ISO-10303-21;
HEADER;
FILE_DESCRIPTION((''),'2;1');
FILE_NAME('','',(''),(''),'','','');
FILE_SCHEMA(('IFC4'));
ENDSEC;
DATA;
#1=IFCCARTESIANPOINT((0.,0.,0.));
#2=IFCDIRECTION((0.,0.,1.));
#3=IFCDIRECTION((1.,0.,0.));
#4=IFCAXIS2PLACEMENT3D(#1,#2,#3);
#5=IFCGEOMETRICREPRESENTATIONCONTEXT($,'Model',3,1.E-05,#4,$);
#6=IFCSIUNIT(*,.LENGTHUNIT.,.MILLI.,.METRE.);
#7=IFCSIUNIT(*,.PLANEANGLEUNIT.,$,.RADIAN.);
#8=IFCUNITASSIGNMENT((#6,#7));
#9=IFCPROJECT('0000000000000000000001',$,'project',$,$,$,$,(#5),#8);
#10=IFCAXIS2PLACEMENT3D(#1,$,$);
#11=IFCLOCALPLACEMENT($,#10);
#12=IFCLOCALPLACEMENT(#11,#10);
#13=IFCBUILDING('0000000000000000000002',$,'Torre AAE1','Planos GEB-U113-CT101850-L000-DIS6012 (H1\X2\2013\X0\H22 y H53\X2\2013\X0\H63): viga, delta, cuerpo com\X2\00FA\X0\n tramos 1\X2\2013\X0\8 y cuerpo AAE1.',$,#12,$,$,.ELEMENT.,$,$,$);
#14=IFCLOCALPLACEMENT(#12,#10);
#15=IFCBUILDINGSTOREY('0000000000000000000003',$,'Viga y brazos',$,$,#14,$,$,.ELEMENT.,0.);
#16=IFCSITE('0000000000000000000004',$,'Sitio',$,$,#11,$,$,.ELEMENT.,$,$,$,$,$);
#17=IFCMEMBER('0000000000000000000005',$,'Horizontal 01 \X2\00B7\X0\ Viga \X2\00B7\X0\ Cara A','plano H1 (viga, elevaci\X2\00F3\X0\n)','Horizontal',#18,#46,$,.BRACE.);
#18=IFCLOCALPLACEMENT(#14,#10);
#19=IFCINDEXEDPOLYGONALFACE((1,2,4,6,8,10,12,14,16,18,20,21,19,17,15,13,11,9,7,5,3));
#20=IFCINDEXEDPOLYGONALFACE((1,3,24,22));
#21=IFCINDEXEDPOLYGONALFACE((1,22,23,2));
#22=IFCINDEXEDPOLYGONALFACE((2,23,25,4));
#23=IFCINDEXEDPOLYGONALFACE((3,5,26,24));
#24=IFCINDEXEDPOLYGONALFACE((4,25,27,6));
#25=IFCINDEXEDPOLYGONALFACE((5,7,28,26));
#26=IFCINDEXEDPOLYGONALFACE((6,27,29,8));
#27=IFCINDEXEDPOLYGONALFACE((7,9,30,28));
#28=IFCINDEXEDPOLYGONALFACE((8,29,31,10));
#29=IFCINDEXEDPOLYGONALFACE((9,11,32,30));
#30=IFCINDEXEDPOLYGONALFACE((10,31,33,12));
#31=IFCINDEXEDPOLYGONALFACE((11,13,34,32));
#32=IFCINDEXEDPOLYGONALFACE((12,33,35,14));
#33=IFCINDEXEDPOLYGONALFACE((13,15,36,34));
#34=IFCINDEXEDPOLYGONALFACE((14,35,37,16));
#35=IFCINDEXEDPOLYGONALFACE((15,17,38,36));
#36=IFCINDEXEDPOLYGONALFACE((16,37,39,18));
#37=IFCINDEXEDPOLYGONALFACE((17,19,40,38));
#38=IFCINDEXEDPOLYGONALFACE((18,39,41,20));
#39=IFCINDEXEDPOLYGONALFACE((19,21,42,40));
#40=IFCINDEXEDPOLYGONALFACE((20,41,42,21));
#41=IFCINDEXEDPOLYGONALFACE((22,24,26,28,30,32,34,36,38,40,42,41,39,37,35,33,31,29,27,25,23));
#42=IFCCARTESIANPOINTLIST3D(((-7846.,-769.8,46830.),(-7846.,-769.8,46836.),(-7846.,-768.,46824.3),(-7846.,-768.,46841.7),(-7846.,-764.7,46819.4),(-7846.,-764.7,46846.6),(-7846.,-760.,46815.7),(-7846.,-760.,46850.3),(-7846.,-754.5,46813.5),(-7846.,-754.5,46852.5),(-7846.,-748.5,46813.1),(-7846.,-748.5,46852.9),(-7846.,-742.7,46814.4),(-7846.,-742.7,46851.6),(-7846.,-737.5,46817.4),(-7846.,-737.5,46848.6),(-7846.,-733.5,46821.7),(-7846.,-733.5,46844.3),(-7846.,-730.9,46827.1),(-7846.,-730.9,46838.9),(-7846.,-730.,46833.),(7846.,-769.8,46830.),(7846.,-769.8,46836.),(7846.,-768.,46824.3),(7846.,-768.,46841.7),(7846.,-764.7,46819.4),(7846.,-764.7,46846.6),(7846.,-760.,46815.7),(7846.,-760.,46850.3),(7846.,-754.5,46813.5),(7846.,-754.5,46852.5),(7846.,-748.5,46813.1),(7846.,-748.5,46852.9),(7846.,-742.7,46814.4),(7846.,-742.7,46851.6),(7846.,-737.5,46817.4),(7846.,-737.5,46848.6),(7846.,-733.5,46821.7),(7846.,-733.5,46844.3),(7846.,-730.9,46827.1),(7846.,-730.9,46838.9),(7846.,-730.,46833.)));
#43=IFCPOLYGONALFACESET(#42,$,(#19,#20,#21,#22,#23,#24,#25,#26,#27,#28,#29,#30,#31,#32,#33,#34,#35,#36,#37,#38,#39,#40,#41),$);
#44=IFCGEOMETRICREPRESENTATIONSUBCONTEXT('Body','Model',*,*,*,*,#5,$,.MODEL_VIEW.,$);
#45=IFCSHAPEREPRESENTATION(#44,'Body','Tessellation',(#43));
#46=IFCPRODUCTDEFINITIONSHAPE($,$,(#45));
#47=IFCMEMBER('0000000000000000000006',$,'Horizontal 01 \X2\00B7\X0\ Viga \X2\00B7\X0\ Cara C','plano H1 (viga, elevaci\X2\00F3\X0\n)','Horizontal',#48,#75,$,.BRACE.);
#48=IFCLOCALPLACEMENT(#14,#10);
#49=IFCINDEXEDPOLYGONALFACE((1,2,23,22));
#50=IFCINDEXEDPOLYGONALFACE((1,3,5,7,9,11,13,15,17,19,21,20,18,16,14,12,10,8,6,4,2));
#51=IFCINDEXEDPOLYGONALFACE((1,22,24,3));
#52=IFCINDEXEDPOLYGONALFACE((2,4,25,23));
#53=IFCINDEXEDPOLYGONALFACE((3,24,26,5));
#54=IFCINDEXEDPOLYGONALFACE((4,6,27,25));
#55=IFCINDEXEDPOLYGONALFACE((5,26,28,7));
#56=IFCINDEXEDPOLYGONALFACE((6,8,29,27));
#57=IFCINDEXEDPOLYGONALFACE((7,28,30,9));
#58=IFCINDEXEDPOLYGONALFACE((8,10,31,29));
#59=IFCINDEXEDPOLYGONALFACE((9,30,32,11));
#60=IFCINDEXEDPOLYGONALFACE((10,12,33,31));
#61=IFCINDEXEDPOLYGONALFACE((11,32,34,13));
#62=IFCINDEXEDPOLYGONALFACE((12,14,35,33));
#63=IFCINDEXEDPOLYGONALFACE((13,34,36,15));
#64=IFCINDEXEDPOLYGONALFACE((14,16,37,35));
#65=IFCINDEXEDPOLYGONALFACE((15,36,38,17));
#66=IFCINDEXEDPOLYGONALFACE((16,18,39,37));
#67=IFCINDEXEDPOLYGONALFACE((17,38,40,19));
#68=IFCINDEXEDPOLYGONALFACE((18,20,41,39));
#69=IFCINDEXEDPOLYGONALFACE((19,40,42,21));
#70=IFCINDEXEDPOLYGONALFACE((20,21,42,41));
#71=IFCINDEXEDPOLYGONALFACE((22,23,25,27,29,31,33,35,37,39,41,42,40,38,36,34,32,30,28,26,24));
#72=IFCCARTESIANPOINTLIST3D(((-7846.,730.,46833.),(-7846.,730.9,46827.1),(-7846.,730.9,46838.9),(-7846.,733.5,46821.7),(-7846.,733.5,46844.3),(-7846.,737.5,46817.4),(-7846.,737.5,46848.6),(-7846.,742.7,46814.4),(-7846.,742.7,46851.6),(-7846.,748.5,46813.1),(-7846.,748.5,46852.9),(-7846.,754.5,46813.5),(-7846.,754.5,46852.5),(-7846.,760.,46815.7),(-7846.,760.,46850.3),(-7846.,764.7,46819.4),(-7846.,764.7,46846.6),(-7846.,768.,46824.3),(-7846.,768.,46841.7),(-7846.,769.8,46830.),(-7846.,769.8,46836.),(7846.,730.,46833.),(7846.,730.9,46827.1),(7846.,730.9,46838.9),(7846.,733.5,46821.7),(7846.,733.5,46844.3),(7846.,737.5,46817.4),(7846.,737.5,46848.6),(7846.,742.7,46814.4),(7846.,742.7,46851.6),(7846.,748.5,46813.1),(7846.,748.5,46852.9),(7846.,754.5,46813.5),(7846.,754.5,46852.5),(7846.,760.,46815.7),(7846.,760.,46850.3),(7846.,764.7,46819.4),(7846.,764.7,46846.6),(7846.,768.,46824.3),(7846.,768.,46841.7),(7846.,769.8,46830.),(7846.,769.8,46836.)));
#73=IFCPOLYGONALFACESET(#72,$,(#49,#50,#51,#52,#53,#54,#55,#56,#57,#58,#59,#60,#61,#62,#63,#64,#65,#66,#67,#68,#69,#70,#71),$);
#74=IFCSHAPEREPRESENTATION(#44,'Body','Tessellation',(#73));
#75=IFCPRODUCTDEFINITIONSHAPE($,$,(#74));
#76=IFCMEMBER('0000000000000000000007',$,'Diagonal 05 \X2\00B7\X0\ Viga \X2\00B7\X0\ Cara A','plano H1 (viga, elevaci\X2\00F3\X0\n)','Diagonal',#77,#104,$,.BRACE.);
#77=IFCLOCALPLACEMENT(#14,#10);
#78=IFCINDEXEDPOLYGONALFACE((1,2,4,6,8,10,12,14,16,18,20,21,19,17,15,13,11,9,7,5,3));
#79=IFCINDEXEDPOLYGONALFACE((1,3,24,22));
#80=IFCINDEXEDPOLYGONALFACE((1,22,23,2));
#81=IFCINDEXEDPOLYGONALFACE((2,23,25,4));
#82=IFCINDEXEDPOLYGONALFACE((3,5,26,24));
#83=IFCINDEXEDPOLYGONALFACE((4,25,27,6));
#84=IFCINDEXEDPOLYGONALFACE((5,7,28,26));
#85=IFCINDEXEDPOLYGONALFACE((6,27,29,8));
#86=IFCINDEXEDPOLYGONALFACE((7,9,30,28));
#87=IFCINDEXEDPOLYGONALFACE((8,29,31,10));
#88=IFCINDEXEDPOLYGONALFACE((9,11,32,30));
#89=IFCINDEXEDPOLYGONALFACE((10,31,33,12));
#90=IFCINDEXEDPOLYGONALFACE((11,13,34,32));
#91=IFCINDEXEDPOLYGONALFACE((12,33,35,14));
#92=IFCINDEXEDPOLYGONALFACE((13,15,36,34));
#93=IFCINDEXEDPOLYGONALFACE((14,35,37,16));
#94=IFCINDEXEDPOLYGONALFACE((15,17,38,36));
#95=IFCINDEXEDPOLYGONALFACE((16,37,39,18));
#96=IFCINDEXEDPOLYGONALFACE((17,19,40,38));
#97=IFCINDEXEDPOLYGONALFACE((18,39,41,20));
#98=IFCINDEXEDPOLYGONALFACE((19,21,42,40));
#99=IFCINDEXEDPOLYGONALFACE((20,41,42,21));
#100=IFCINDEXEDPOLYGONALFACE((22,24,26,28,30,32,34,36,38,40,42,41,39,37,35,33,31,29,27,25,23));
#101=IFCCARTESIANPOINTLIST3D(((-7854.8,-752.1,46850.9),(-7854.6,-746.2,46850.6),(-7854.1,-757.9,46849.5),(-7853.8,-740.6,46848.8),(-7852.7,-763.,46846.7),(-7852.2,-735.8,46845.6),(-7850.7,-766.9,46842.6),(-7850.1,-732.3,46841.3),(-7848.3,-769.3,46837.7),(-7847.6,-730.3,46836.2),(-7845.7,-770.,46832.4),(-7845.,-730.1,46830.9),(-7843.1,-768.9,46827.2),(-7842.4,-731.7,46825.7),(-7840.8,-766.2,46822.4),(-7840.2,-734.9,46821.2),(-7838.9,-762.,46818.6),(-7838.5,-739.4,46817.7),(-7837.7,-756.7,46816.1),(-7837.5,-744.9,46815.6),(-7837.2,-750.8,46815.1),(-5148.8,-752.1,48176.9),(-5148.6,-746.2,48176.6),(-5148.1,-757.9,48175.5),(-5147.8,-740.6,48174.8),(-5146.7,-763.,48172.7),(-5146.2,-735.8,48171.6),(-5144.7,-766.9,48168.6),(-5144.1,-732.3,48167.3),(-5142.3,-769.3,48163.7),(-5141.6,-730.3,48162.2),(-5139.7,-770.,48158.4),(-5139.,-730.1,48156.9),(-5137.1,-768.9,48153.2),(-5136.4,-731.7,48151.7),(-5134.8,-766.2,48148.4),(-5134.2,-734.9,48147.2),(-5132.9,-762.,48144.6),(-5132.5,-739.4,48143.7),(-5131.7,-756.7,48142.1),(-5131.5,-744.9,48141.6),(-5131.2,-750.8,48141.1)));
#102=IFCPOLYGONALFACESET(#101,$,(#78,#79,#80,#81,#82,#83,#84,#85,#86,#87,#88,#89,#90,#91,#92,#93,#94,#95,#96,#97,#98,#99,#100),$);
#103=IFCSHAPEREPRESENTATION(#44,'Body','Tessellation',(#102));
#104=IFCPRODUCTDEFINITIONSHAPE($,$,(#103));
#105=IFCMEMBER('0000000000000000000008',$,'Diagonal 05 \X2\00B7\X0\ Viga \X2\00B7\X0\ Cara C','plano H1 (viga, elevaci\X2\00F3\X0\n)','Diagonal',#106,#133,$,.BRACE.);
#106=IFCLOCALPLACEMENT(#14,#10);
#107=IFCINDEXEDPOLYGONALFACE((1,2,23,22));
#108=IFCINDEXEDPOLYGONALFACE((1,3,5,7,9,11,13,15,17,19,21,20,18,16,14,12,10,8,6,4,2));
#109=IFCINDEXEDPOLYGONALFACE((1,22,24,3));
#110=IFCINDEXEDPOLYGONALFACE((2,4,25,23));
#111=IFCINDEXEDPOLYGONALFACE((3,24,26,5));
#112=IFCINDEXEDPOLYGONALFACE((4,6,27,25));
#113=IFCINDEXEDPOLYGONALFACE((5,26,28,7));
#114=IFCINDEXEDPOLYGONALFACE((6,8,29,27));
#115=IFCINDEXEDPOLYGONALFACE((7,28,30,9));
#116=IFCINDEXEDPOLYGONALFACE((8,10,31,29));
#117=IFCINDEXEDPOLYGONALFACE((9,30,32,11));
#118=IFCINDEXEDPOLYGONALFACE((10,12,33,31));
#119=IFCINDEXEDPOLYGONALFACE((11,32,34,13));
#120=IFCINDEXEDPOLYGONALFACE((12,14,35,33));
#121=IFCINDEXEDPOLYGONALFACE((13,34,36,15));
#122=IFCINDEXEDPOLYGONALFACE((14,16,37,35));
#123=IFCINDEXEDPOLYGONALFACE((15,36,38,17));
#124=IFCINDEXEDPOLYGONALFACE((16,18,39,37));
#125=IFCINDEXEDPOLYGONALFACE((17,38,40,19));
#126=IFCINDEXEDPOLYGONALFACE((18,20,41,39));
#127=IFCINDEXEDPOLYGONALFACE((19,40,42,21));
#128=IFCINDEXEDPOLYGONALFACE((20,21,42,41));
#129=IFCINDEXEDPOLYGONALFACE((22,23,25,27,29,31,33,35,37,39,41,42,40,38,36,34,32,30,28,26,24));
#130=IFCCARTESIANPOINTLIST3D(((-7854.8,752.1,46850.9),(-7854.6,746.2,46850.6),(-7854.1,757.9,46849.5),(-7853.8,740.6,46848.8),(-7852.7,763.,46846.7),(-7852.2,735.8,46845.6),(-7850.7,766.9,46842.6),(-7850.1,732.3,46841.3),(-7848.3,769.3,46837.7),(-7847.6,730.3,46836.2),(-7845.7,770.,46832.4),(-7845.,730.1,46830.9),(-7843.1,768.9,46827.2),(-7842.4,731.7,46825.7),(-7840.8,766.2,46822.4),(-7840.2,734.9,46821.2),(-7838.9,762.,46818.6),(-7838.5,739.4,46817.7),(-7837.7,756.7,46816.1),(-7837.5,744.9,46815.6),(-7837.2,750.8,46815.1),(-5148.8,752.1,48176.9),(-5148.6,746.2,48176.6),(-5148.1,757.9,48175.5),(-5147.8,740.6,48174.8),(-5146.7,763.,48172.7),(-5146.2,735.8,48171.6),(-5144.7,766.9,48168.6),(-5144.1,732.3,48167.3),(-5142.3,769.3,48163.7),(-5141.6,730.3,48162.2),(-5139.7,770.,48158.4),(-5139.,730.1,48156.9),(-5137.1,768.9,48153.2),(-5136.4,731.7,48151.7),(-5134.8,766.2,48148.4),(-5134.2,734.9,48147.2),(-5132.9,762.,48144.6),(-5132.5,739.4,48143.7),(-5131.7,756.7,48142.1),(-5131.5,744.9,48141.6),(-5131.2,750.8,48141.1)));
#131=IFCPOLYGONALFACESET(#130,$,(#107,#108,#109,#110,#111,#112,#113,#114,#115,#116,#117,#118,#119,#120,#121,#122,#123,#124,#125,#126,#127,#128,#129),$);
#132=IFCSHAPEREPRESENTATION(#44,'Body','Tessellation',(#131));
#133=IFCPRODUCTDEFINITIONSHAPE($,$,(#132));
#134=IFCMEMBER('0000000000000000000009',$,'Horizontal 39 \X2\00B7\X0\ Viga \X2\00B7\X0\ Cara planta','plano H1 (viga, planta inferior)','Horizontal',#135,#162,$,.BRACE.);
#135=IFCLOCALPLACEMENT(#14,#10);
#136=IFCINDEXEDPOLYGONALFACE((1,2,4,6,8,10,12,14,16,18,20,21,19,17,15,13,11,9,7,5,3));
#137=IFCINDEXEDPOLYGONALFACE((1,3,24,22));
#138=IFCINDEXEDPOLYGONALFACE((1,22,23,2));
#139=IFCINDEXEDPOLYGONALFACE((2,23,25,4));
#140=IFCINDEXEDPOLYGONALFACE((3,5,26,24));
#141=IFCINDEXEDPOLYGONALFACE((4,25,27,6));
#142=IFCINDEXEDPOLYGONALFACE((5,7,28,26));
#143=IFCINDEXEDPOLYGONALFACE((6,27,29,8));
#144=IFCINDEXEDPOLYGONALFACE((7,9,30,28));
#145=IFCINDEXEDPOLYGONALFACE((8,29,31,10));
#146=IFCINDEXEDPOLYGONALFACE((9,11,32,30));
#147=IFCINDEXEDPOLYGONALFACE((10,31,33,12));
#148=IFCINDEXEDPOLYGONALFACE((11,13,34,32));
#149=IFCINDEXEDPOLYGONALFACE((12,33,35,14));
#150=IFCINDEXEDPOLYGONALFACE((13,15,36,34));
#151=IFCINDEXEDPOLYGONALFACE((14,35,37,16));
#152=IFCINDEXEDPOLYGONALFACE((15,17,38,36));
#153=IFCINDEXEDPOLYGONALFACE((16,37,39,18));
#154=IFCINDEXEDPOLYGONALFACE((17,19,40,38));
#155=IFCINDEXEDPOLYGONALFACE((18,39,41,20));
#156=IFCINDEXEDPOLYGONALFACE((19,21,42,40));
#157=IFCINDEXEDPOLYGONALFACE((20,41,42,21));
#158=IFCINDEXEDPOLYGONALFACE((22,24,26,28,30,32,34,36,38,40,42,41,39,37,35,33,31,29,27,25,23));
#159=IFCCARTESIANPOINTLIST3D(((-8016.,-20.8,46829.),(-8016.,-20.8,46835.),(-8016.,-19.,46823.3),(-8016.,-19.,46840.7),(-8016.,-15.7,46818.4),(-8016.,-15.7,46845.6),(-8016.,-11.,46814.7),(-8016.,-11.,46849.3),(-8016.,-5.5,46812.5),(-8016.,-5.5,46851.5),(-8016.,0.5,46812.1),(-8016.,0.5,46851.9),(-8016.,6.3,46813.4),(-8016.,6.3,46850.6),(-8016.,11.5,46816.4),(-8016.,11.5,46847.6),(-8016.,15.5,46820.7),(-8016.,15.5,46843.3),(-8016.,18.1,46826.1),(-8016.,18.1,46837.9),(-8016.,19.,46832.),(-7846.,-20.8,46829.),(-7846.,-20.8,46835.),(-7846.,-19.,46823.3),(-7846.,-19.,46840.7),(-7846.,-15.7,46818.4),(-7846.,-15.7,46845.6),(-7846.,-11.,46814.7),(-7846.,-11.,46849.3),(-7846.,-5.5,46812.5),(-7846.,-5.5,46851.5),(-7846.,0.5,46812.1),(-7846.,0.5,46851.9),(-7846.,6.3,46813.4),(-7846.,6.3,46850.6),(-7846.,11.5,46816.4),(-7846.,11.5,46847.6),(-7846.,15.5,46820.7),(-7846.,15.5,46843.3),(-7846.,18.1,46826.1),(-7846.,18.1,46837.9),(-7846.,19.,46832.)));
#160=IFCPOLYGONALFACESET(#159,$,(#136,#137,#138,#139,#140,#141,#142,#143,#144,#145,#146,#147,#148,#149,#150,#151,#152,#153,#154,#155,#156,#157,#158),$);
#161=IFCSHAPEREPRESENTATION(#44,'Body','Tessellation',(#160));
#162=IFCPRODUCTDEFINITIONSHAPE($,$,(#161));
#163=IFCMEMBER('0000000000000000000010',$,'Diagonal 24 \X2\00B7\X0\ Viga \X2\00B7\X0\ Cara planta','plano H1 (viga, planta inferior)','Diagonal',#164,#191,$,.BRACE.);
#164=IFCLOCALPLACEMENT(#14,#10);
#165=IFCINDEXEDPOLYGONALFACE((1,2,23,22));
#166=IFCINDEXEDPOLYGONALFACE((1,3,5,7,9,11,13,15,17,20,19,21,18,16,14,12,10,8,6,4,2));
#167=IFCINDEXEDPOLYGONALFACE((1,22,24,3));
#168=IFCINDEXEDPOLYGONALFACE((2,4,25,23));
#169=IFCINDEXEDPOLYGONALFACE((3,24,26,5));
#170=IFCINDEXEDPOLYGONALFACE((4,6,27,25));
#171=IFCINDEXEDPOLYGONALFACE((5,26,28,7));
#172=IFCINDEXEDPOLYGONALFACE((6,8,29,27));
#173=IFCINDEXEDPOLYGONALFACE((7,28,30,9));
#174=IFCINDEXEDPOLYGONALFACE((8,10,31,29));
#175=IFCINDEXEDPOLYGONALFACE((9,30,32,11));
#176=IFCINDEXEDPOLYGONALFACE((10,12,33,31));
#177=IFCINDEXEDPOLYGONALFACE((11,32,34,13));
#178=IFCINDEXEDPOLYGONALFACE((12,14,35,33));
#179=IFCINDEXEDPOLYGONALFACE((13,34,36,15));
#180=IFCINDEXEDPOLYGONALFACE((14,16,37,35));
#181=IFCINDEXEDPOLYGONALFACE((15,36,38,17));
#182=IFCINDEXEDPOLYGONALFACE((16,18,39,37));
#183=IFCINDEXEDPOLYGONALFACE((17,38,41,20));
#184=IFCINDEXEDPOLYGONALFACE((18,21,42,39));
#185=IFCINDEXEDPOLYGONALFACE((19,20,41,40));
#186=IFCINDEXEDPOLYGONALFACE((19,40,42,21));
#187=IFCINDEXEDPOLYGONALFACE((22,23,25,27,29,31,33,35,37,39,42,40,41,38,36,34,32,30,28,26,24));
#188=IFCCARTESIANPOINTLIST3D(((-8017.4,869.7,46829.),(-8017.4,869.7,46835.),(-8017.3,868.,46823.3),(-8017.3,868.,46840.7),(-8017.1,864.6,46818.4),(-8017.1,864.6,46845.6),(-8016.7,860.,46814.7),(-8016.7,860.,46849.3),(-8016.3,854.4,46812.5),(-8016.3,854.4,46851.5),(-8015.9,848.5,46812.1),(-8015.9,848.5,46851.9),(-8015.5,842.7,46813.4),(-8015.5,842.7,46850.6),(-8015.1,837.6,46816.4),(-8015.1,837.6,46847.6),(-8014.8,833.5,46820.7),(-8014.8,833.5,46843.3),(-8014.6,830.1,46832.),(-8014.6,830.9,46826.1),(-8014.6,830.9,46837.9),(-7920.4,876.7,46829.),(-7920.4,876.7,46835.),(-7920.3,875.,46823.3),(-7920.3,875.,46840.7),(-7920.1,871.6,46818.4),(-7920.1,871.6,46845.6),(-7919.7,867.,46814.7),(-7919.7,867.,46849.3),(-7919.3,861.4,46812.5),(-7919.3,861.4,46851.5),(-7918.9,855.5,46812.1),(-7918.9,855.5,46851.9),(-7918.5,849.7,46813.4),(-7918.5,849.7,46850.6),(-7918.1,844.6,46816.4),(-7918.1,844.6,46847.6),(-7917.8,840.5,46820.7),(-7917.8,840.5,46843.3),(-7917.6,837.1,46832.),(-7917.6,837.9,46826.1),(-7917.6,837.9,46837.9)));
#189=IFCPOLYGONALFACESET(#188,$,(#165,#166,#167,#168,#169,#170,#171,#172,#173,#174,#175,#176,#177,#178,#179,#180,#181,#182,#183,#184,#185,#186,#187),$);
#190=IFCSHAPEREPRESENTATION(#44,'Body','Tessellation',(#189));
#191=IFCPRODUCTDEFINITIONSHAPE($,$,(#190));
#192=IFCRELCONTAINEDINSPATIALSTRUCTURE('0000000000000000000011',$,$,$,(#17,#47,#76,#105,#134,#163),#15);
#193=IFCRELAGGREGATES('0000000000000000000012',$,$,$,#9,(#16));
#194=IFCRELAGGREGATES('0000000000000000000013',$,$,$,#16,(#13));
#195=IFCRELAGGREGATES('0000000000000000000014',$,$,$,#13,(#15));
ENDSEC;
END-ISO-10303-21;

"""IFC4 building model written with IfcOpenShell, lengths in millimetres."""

from ifc_helpers import new_model, si_unit, frame, origin, origin_with_axes, place, context, subcontext, project, spatial, circle, extrude, element, save


model = new_model("IFC4")

# Units and contexts
model_context = context("Model", 3, precision=1e-05, world=origin_with_axes())
body_context = subcontext(model_context, "Body", "Model", "MODEL_VIEW")
ifc_project = project(units=[si_unit("LENGTHUNIT", "METRE", prefix="MILLI"), si_unit("PLANEANGLEUNIT", "RADIAN")], contexts=[model_context])

# Site, building, storey
site_placement = place(None, origin())
site = spatial("IfcSite", under=ifc_project, at=site_placement, Name="Sitio", CompositionType="ELEMENT")
building_placement = place(site_placement, origin())
building = spatial("IfcBuilding", under=site, at=building_placement, Name="Torre AAE1", Description="Planos GEB-U113-CT101850-L000-DIS6012 (H1–H22 y H53–H63): viga, delta, cuerpo común tramos 1–8 y cuerpo AAE1.", CompositionType="ELEMENT")
storey_placement = place(building_placement, origin())
storey = spatial("IfcBuildingStorey", under=building, at=storey_placement, Name="Viga y brazos", CompositionType="ELEMENT", Elevation=0.0)

# Members
for number, where, z_axis, x_axis, name in (
    (1, (-7846.0, -750.0, 46833.0), (1.0, 0.0, 0.0), (0.0, 1.0, 0.0), "Horizontal 01 · Viga · Cara A"),
    (2, (-7846.0, 750.0, 46833.0), (1.0, 0.0, 0.0), (0.0, -1.0, 0.0), "Horizontal 01 · Viga · Cara C"),
):
    element("IfcMember", number, at=place(storey_placement, frame(where, z_axis=z_axis, x_axis=x_axis)), inside=storey, Name=name, Description="plano H1 (viga, elevación)", ObjectType="Horizontal", PredefinedType="BRACE", context=body_context, shape_type="SweptSolid", body=[
        extrude(circle(Radius=20.0), None, (0.0, 0.0, 1.0), 15692.0),
    ])
for number, where, z_axis, x_axis, name in (
    (3, (-7846.0, -750.0, 46833.0), (0.897982, 0.0, 0.440031), (0.425612, 0.2539, -0.868556), "Diagonal 05 · Viga · Cara A"),
    (4, (-7846.0, 750.0, 46833.0), (0.897982, 0.0, 0.440031), (0.425612, -0.2539, -0.868556), "Diagonal 05 · Viga · Cara C"),
):
    element("IfcMember", number, at=place(storey_placement, frame(where, z_axis=z_axis, x_axis=x_axis)), inside=storey, Name=name, Description="plano H1 (viga, elevación)", ObjectType="Diagonal", PredefinedType="BRACE", context=body_context, shape_type="SweptSolid", body=[
        extrude(circle(Radius=20.0), None, (0.0, 0.0, 1.0), 3013.4),
    ])
member_1_placement = place(storey_placement, frame((-7846.0, -1.0, 46832.0), z_axis=(-1.0, 0.0, 0.0), x_axis=(0.0, 1.0, 0.0)))
element("IfcMember", 5, at=member_1_placement, inside=storey, Name="Horizontal 39 · Viga · Cara planta", Description="plano H1 (viga, planta inferior)", ObjectType="Horizontal", PredefinedType="BRACE", context=body_context, shape_type="SweptSolid", body=[
    extrude(circle(Radius=20.0), None, (0.0, 0.0, 1.0), 170.0),
])
member_2_placement = place(storey_placement, frame((-8016.0, 850.0, 46832.0), z_axis=(0.997406, 0.071978, 0.0), x_axis=(0.071978, -0.997406, 0.0)))
element("IfcMember", 6, at=member_2_placement, inside=storey, Name="Diagonal 24 · Viga · Cara planta", Description="plano H1 (viga, planta inferior)", ObjectType="Diagonal", PredefinedType="BRACE", context=body_context, shape_type="SweptSolid", body=[
    extrude(circle(Radius=20.0), None, (0.0, 0.0, 1.0), 97.3),
])

save(model, "model.ifc")
